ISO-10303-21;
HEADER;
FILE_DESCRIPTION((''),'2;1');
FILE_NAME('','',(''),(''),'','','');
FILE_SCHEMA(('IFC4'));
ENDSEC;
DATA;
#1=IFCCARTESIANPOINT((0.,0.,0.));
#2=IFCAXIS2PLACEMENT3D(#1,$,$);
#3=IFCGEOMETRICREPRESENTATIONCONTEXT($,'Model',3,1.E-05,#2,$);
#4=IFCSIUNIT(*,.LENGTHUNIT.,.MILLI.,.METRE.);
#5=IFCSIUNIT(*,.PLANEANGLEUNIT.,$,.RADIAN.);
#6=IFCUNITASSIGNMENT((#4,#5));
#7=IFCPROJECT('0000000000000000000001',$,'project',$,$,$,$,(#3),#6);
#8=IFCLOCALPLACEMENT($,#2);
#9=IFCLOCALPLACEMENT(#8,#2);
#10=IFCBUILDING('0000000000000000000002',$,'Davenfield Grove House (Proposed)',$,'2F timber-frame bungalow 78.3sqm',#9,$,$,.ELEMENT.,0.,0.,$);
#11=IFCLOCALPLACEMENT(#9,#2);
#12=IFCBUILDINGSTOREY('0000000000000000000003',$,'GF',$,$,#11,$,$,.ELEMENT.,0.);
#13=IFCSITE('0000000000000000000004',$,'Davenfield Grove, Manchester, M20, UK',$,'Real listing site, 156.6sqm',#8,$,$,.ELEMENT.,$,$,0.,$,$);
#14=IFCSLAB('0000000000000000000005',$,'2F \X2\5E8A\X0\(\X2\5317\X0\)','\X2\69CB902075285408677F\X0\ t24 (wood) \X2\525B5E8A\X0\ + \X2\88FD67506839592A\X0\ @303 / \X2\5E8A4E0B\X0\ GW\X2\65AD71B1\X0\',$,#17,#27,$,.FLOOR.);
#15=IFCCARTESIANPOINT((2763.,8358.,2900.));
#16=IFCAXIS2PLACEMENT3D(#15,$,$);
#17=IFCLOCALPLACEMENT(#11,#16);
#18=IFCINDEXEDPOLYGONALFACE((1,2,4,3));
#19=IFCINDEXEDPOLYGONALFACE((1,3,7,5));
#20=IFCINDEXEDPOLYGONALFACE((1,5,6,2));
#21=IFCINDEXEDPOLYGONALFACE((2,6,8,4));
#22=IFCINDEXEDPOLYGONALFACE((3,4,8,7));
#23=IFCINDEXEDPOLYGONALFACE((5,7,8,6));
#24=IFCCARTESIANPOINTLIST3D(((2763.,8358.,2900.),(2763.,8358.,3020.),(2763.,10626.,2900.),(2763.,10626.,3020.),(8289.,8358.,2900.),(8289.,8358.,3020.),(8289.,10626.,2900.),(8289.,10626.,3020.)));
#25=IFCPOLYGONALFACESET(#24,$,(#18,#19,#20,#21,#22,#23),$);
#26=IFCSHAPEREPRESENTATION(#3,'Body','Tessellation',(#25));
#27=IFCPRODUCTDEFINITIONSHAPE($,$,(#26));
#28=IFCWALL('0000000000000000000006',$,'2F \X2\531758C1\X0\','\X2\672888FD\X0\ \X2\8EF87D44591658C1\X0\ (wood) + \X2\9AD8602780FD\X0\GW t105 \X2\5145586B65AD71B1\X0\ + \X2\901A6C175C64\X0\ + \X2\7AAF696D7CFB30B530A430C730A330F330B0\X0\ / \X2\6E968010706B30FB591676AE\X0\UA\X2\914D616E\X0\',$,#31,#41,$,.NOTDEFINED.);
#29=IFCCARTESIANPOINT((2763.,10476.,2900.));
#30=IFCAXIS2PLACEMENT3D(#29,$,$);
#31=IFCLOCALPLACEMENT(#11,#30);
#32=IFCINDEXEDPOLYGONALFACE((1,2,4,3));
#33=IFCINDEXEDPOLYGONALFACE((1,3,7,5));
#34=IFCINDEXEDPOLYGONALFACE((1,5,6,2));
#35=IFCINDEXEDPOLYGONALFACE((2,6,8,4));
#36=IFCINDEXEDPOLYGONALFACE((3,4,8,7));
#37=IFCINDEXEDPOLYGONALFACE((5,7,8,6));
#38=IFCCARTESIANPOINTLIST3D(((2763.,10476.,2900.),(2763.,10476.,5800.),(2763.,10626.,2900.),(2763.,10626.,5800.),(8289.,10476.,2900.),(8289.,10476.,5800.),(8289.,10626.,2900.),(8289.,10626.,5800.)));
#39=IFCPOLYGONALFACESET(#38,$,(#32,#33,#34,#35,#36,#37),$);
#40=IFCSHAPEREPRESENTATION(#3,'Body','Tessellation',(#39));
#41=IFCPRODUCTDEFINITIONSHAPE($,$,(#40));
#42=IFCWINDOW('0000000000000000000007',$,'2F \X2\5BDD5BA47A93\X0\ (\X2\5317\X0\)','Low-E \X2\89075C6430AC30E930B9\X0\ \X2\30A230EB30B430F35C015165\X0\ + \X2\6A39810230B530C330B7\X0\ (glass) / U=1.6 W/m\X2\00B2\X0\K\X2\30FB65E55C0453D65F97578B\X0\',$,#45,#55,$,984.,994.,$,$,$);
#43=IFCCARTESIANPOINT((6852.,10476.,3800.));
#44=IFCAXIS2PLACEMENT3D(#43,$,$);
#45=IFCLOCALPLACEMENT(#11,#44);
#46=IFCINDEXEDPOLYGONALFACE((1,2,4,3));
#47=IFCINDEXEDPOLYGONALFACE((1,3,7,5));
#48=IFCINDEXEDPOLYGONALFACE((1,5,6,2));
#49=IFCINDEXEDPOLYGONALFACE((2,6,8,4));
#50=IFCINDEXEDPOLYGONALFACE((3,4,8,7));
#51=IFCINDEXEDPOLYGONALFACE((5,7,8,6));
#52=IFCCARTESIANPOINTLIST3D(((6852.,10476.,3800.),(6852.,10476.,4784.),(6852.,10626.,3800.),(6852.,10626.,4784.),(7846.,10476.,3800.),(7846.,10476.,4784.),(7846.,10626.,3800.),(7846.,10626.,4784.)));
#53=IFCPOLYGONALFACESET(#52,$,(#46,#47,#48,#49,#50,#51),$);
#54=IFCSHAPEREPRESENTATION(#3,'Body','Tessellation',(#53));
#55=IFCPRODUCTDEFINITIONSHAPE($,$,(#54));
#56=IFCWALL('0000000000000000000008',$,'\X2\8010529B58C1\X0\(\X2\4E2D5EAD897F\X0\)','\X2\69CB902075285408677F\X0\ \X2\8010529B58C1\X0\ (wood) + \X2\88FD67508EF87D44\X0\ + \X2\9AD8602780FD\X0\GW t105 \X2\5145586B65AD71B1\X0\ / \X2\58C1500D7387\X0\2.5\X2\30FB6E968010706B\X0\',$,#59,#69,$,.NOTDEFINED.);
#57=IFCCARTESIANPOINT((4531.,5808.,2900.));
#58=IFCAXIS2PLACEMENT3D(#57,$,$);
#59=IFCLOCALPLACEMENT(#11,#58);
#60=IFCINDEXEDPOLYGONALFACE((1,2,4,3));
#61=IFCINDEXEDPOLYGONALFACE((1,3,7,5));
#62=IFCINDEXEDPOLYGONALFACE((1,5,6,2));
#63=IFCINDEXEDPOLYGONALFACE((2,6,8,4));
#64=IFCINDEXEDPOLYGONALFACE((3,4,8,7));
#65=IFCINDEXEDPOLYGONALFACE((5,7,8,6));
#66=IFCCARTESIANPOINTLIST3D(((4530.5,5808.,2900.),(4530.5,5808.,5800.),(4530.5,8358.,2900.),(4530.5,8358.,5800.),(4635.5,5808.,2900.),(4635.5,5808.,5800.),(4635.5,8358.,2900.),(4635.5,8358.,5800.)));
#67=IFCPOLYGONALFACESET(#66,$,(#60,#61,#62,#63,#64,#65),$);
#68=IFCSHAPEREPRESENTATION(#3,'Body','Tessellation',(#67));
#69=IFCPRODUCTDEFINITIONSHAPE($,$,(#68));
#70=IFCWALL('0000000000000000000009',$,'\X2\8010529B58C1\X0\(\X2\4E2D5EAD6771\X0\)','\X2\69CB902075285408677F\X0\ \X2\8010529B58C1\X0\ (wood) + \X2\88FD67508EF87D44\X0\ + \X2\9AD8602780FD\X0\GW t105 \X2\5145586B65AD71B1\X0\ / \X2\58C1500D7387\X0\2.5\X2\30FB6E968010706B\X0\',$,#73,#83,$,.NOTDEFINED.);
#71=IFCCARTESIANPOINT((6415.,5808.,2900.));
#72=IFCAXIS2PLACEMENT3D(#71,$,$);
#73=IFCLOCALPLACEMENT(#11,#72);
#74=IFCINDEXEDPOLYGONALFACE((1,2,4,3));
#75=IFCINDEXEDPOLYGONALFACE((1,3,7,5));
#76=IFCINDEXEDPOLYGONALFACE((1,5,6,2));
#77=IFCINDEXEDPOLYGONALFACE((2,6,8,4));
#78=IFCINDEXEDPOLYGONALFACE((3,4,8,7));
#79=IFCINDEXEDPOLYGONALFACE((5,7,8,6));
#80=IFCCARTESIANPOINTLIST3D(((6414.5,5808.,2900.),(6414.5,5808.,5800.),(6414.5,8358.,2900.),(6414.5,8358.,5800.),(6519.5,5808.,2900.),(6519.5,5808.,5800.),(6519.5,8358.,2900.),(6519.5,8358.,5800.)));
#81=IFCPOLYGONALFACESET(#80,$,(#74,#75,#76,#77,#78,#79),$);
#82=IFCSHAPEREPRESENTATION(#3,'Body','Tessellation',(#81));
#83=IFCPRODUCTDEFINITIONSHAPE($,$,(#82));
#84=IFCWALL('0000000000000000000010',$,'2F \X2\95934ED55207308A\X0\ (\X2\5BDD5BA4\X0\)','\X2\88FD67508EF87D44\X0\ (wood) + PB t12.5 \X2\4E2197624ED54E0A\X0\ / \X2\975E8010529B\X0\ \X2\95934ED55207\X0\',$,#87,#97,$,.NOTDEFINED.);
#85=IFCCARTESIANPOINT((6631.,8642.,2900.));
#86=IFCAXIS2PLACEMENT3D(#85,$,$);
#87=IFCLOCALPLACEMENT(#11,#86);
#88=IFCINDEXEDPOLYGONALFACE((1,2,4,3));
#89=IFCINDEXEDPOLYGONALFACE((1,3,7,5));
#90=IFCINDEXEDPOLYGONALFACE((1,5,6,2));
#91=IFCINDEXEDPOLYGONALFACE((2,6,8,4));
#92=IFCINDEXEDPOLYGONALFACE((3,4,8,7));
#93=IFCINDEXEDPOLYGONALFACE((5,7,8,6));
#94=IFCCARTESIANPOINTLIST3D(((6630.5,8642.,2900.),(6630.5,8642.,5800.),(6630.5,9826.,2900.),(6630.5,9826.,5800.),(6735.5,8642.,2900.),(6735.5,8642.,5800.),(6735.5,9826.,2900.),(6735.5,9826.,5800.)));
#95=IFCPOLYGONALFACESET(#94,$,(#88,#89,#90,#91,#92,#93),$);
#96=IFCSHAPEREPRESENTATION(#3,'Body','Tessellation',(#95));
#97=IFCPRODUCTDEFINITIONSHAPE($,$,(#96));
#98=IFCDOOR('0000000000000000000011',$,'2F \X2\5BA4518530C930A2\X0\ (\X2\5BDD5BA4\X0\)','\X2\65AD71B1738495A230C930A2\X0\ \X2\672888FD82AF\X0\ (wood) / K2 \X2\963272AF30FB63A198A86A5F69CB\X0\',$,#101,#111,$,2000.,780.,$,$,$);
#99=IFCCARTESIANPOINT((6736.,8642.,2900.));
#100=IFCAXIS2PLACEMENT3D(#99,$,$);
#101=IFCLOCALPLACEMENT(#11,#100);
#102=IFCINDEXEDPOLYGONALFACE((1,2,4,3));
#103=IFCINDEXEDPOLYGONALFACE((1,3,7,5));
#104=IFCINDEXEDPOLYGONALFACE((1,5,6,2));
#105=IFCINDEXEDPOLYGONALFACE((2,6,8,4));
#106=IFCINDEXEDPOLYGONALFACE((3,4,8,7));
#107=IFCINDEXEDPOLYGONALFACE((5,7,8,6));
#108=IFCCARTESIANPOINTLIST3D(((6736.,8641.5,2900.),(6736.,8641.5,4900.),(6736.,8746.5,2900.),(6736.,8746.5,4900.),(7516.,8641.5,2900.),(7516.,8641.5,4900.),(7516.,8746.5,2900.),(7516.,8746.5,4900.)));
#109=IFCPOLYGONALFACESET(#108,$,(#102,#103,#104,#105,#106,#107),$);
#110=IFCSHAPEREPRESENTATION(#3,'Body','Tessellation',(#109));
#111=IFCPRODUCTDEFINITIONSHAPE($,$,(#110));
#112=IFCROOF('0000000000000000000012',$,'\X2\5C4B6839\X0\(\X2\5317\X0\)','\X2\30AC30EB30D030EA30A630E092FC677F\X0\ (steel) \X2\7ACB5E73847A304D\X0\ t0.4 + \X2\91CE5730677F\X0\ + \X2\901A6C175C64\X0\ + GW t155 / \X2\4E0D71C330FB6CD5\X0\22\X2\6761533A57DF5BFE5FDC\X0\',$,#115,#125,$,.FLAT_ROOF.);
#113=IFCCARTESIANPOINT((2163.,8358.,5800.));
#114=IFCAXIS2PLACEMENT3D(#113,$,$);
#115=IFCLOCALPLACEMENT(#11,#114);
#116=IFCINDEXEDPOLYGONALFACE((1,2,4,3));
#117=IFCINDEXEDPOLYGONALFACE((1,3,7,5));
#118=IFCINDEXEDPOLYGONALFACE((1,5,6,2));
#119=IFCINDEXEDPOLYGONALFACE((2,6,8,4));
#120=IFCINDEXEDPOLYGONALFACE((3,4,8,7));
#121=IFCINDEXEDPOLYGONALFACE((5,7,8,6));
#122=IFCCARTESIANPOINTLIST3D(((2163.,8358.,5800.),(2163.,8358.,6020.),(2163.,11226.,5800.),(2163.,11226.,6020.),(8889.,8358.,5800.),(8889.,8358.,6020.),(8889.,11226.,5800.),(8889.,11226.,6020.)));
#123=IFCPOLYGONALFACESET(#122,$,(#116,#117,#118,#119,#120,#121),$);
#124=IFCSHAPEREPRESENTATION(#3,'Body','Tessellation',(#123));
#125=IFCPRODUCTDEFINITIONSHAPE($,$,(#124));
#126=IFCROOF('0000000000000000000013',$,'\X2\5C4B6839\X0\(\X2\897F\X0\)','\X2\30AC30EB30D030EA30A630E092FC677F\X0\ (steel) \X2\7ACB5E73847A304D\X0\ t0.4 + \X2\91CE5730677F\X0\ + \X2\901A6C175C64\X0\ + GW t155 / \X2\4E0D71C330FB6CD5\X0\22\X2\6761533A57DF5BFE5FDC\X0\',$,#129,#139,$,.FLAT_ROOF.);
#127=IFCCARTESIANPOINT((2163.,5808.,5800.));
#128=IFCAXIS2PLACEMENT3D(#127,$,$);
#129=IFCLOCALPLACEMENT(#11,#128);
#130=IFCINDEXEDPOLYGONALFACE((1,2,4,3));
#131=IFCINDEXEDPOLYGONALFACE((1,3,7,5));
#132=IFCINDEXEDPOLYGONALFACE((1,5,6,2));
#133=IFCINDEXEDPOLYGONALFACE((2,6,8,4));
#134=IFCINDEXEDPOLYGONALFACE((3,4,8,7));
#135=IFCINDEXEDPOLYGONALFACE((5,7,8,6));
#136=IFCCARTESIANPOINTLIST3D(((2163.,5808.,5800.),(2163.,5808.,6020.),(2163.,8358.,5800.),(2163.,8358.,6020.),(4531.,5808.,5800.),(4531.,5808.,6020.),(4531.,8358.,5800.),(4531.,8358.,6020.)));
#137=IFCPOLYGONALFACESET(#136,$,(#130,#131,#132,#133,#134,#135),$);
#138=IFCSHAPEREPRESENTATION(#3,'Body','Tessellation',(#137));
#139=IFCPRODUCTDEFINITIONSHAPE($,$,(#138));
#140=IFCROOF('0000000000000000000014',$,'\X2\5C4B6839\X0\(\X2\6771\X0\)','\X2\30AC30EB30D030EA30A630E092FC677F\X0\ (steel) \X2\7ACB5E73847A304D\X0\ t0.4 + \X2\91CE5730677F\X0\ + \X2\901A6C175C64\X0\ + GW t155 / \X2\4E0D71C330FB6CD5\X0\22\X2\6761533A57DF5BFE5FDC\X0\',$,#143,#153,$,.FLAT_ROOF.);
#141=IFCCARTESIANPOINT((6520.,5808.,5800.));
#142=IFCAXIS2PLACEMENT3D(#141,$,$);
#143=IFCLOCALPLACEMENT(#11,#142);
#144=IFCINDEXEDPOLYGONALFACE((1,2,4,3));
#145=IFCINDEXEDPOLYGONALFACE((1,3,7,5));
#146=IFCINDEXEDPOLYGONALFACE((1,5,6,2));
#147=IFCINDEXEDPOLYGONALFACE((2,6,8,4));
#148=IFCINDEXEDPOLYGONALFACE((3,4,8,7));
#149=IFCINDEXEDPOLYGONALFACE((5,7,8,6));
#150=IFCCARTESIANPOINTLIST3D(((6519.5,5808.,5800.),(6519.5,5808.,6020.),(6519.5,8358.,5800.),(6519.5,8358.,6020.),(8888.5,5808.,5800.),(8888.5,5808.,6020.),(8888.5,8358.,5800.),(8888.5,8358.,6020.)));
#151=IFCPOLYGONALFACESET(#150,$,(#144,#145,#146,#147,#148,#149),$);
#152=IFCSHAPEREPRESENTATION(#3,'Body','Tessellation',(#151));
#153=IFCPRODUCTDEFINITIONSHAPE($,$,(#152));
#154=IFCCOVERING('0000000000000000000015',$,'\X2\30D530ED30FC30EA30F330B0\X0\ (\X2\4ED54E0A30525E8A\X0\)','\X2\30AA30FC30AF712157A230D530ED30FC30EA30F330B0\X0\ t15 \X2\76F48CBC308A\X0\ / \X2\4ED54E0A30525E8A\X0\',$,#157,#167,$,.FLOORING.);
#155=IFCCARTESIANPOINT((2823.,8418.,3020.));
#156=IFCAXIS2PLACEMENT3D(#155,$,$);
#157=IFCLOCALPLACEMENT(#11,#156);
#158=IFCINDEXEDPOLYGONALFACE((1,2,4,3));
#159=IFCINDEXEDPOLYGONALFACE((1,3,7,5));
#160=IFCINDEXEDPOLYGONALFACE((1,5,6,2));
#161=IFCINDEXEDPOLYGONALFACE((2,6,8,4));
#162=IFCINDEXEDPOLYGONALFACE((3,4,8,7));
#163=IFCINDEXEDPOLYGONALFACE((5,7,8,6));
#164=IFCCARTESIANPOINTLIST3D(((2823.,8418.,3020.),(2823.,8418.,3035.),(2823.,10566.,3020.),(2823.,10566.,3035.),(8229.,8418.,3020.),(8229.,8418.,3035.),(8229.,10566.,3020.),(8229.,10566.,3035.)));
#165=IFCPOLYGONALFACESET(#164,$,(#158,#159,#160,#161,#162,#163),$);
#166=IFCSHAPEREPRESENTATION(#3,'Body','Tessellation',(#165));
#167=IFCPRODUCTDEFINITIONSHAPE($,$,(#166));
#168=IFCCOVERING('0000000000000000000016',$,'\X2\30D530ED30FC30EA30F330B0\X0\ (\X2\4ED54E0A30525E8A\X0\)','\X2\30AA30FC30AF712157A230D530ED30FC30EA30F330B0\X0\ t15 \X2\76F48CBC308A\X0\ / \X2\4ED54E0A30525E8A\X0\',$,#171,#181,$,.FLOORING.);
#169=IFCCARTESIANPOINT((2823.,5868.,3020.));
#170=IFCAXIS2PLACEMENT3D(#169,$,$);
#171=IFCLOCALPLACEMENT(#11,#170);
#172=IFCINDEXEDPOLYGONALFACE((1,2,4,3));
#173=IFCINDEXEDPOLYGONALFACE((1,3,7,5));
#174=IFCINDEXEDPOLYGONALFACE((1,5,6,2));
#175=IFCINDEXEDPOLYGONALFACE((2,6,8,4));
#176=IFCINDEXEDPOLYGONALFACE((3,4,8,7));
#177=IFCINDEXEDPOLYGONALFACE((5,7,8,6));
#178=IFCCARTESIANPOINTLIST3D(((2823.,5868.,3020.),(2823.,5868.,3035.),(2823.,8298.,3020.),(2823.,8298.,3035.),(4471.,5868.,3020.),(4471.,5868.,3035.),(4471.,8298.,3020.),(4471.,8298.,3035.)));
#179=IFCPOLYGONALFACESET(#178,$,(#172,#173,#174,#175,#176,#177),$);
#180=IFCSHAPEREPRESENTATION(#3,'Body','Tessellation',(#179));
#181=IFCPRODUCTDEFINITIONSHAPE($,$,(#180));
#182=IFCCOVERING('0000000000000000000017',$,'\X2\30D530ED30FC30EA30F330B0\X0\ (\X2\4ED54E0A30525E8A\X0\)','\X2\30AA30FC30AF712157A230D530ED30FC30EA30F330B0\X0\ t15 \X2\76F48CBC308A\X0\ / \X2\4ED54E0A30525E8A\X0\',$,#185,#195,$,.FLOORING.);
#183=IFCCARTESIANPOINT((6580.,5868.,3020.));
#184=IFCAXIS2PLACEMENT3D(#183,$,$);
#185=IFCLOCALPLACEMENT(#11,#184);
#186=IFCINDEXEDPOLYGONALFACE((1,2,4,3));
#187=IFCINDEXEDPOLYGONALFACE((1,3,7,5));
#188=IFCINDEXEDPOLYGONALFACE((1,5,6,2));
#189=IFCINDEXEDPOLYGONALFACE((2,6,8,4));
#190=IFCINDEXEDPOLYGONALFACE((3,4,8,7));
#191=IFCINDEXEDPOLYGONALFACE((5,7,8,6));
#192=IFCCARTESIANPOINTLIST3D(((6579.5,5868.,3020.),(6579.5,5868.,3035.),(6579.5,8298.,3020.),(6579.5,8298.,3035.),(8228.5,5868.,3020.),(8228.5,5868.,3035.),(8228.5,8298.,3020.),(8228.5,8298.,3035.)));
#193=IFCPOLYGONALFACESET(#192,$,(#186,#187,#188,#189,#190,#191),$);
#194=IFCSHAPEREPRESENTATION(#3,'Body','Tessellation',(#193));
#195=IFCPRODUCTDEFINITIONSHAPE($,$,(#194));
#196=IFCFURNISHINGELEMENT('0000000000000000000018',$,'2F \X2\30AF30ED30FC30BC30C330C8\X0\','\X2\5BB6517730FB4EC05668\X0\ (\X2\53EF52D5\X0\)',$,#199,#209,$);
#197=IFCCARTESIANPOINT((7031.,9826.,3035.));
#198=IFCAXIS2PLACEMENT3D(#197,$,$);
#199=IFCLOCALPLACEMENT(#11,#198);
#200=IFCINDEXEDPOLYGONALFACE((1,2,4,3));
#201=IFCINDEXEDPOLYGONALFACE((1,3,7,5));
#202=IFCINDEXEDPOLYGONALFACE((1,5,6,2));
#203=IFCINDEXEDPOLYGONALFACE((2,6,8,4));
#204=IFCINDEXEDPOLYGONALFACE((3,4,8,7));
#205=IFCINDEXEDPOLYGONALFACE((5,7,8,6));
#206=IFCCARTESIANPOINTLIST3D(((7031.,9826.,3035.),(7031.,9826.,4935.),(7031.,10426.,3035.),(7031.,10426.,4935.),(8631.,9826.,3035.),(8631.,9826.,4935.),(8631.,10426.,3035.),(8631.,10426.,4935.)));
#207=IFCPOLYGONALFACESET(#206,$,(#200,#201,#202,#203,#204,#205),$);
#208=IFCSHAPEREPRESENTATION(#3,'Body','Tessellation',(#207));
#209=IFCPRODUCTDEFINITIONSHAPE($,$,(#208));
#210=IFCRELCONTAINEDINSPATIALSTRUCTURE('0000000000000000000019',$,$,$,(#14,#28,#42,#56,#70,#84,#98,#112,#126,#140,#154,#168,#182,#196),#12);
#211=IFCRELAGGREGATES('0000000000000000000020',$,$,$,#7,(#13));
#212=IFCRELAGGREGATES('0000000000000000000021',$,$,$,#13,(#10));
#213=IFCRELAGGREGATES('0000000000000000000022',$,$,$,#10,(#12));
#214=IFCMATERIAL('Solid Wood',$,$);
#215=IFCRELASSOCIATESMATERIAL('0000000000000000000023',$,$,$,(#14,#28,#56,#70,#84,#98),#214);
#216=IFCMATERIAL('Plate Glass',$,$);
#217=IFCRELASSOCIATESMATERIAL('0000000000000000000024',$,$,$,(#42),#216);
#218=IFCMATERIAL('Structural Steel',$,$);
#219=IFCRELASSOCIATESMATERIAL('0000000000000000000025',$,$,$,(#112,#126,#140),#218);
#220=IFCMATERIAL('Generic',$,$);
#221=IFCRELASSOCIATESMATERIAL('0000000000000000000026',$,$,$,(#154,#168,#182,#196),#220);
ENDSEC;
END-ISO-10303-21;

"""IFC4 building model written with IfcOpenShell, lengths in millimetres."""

from ifc_helpers import new_model, si_unit, frame, frame_2d, origin, place, context, project, spatial, rectangle, extrude, material, element, fill, save


model = new_model("IFC4")

# Units and contexts
model_context = context("Model", 3, precision=1e-05, world=origin())
ifc_project = project(units=[si_unit("LENGTHUNIT", "METRE", prefix="MILLI"), si_unit("PLANEANGLEUNIT", "RADIAN")], contexts=[model_context])

# Site, building, storey
site_placement = place(None, origin())
site = spatial("IfcSite", under=ifc_project, at=site_placement, Name="Davenfield Grove, Manchester, M20, UK", ObjectType="Real listing site, 156.6sqm", CompositionType="ELEMENT", RefElevation=0.0)
building_placement = place(site_placement, origin())
building = spatial("IfcBuilding", under=site, at=building_placement, Name="Davenfield Grove House (Proposed)", ObjectType="2F timber-frame bungalow 78.3sqm", CompositionType="ELEMENT", ElevationOfRefHeight=0.0, ElevationOfTerrain=0.0)
storey_placement = place(building_placement, origin())
storey = spatial("IfcBuildingStorey", under=building, at=storey_placement, Name="GF", CompositionType="ELEMENT", Elevation=0.0)

# Slab
ifc_material_1 = material(Name="Solid Wood")
slab_placement = place(storey_placement, frame((2763.0, 8358.0, 2900.0)))
element("IfcSlab", 1, at=slab_placement, inside=storey, material=ifc_material_1, Name="2F 床(北)", Description="構造用合板 t24 (wood) 剛床 + 製材根太 @303 / 床下 GW断熱", PredefinedType="FLOOR", context=model_context, shape_type="SweptSolid", body=[
    extrude(rectangle(XDim=5526.0, YDim=2268.0, at=frame_2d((2763.0, 1134.0))), frame((2763.0, 8358.0, 2900.0)), (0.0, 0.0, 1.0), 120.0),
])

# Wall, opening, window
wall_1_placement = place(storey_placement, frame((2763.0, 10476.0, 2900.0)))
wall_1 = element("IfcWall", 2, at=wall_1_placement, inside=storey, material=ifc_material_1, Name="2F 北壁", Description="木製 軸組外壁 (wood) + 高性能GW t105 充填断熱 + 通気層 + 窯業系サイディング / 準耐火・外皮UA配慮", PredefinedType="NOTDEFINED", context=model_context, shape_type="SweptSolid", body=[
    extrude(rectangle(XDim=5526.0, YDim=150.0, at=frame_2d((2763.0, 75.0))), frame((2763.0, 10476.0, 2900.0)), (0.0, 0.0, 1.0), 2900.0),
])
opening_1_placement = place(storey_placement, frame((6852.0, 10476.0, 3800.0)))
opening_1 = element("IfcOpeningElement", 3, at=opening_1_placement, cuts=wall_1, PredefinedType="NOTDEFINED", context=model_context, shape_type="SweptSolid", body=[
    extrude(rectangle(XDim=994.0, YDim=150.0, at=frame_2d((497.0, 75.0))), frame((6852.0, 10476.0, 3800.0)), (0.0, 0.0, 1.0), 984.0),
])
ifc_material_2 = material(Name="Plate Glass")
window_1_placement = place(storey_placement, frame((6852.0, 10476.0, 3800.0)))
window_1 = element("IfcWindow", 4, at=window_1_placement, inside=storey, material=ifc_material_2, Name="2F 寝室窓 (北)", Description="Low-E 複層ガラス アルゴン封入 + 樹脂サッシ (glass) / U=1.6 W/m²K・日射取得型", OverallHeight=984.0, OverallWidth=994.0, context=model_context, shape_type="SweptSolid", body=[
    extrude(rectangle(XDim=994.0, YDim=150.0, at=frame_2d((497.0, 75.0))), frame((6852.0, 10476.0, 3800.0)), (0.0, 0.0, 1.0), 984.0),
])
fill(opening_1, window_1)

# Walls
wall_2_placement = place(storey_placement, frame((4531.0, 5808.0, 2900.0)))
element("IfcWall", 5, at=wall_2_placement, inside=storey, material=ifc_material_1, Name="耐力壁(中庭西)", Description="構造用合板 耐力壁 (wood) + 製材軸組 + 高性能GW t105 充填断熱 / 壁倍率2.5・準耐火", PredefinedType="NOTDEFINED", context=model_context, shape_type="SweptSolid", body=[
    extrude(rectangle(XDim=105.0, YDim=2550.0, at=frame_2d((52.0, 1275.0))), frame((4531.0, 5808.0, 2900.0)), (0.0, 0.0, 1.0), 2900.0),
])
wall_3_placement = place(storey_placement, frame((6415.0, 5808.0, 2900.0)))
element("IfcWall", 6, at=wall_3_placement, inside=storey, material=ifc_material_1, Name="耐力壁(中庭東)", Description="構造用合板 耐力壁 (wood) + 製材軸組 + 高性能GW t105 充填断熱 / 壁倍率2.5・準耐火", PredefinedType="NOTDEFINED", context=model_context, shape_type="SweptSolid", body=[
    extrude(rectangle(XDim=105.0, YDim=2550.0, at=frame_2d((52.0, 1275.0))), frame((6415.0, 5808.0, 2900.0)), (0.0, 0.0, 1.0), 2900.0),
])
wall_4_placement = place(storey_placement, frame((6631.0, 8642.0, 2900.0)))
element("IfcWall", 7, at=wall_4_placement, inside=storey, material=ifc_material_1, Name="2F 間仕切り (寝室)", Description="製材軸組 (wood) + PB t12.5 両面仕上 / 非耐力 間仕切", PredefinedType="NOTDEFINED", context=model_context, shape_type="SweptSolid", body=[
    extrude(rectangle(XDim=105.0, YDim=1184.0, at=frame_2d((52.0, 592.0))), frame((6631.0, 8642.0, 2900.0)), (0.0, 0.0, 1.0), 2900.0),
])

# Door
door_placement = place(storey_placement, frame((6736.0, 8642.0, 2900.0)))
element("IfcDoor", 8, at=door_placement, inside=storey, material=ifc_material_1, Name="2F 室内ドア (寝室)", Description="断熱玄関ドア 木製芯 (wood) / K2 防犯・採風機構", OverallHeight=2000.0, OverallWidth=780.0, context=model_context, shape_type="SweptSolid", body=[
    extrude(rectangle(XDim=780.0, YDim=105.0, at=frame_2d((390.0, 52.0))), frame((6736.0, 8642.0, 2900.0)), (0.0, 0.0, 1.0), 2000.0),
])

# Roofs
ifc_material_3 = material(Name="Structural Steel")
for number, where, name in (
    (9, (2163.0, 8358.0, 5800.0), "屋根(北)"),
):
    element("IfcRoof", number, at=place(storey_placement, frame(where)), inside=storey, material=ifc_material_3, Name=name, Description="ガルバリウム鋼板 (steel) 立平葺き t0.4 + 野地板 + 通気層 + GW t155 / 不燃・法22条区域対応", PredefinedType="FLAT_ROOF", context=model_context, shape_type="SweptSolid", body=[
        extrude(rectangle(XDim=6726.0, YDim=2868.0, at=frame_2d((3363.0, 1434.0))), frame((2163.0, 8358.0, 5800.0)), (0.0, 0.0, 1.0), 220.0),
    ])
roof_1_placement = place(storey_placement, frame((2163.0, 5808.0, 5800.0)))
element("IfcRoof", 10, at=roof_1_placement, inside=storey, material=ifc_material_3, Name="屋根(西)", Description="ガルバリウム鋼板 (steel) 立平葺き t0.4 + 野地板 + 通気層 + GW t155 / 不燃・法22条区域対応", PredefinedType="FLAT_ROOF", context=model_context, shape_type="SweptSolid", body=[
    extrude(rectangle(XDim=2368.0, YDim=2550.0, at=frame_2d((1184.0, 1275.0))), frame((2163.0, 5808.0, 5800.0)), (0.0, 0.0, 1.0), 220.0),
])
roof_2_placement = place(storey_placement, frame((6520.0, 5808.0, 5800.0)))
element("IfcRoof", 11, at=roof_2_placement, inside=storey, material=ifc_material_3, Name="屋根(東)", Description="ガルバリウム鋼板 (steel) 立平葺き t0.4 + 野地板 + 通気層 + GW t155 / 不燃・法22条区域対応", PredefinedType="FLAT_ROOF", context=model_context, shape_type="SweptSolid", body=[
    extrude(rectangle(XDim=2369.0, YDim=2550.0, at=frame_2d((1184.0, 1275.0))), frame((6520.0, 5808.0, 5800.0)), (0.0, 0.0, 1.0), 220.0),
])

# Coverings
ifc_material_4 = material(Name="Generic")
covering_1_placement = place(storey_placement, frame((2823.0, 8418.0, 3020.0)))
element("IfcCovering", 12, at=covering_1_placement, inside=storey, material=ifc_material_4, Name="フローリング (仕上げ床)", Description="オーク無垢フローリング t15 直貼り / 仕上げ床", PredefinedType="FLOORING", context=model_context, shape_type="SweptSolid", body=[
    extrude(rectangle(XDim=5406.0, YDim=2148.0, at=frame_2d((2703.0, 1074.0))), frame((2823.0, 8418.0, 3020.0)), (0.0, 0.0, 1.0), 15.0),
])
covering_2_placement = place(storey_placement, frame((2823.0, 5868.0, 3020.0)))
element("IfcCovering", 13, at=covering_2_placement, inside=storey, material=ifc_material_4, Name="フローリング (仕上げ床)", Description="オーク無垢フローリング t15 直貼り / 仕上げ床", PredefinedType="FLOORING", context=model_context, shape_type="SweptSolid", body=[
    extrude(rectangle(XDim=1648.0, YDim=2430.0, at=frame_2d((824.0, 1215.0))), frame((2823.0, 5868.0, 3020.0)), (0.0, 0.0, 1.0), 15.0),
])
covering_3_placement = place(storey_placement, frame((6580.0, 5868.0, 3020.0)))
element("IfcCovering", 14, at=covering_3_placement, inside=storey, material=ifc_material_4, Name="フローリング (仕上げ床)", Description="オーク無垢フローリング t15 直貼り / 仕上げ床", PredefinedType="FLOORING", context=model_context, shape_type="SweptSolid", body=[
    extrude(rectangle(XDim=1649.0, YDim=2430.0, at=frame_2d((824.0, 1215.0))), frame((6580.0, 5868.0, 3020.0)), (0.0, 0.0, 1.0), 15.0),
])

# Furnishing element
furnishing_1_placement = place(storey_placement, frame((7031.0, 9826.0, 3035.0)))
element("IfcFurnishingElement", 15, at=furnishing_1_placement, inside=storey, material=ifc_material_4, Name="2F クローゼット", Description="家具・什器 (可動)", context=model_context, shape_type="SweptSolid", body=[
    extrude(rectangle(XDim=1600.0, YDim=600.0, at=frame_2d((800.0, 300.0))), frame((7031.0, 9826.0, 3035.0)), (0.0, 0.0, 1.0), 1900.0),
])

save(model, "model.ifc")
